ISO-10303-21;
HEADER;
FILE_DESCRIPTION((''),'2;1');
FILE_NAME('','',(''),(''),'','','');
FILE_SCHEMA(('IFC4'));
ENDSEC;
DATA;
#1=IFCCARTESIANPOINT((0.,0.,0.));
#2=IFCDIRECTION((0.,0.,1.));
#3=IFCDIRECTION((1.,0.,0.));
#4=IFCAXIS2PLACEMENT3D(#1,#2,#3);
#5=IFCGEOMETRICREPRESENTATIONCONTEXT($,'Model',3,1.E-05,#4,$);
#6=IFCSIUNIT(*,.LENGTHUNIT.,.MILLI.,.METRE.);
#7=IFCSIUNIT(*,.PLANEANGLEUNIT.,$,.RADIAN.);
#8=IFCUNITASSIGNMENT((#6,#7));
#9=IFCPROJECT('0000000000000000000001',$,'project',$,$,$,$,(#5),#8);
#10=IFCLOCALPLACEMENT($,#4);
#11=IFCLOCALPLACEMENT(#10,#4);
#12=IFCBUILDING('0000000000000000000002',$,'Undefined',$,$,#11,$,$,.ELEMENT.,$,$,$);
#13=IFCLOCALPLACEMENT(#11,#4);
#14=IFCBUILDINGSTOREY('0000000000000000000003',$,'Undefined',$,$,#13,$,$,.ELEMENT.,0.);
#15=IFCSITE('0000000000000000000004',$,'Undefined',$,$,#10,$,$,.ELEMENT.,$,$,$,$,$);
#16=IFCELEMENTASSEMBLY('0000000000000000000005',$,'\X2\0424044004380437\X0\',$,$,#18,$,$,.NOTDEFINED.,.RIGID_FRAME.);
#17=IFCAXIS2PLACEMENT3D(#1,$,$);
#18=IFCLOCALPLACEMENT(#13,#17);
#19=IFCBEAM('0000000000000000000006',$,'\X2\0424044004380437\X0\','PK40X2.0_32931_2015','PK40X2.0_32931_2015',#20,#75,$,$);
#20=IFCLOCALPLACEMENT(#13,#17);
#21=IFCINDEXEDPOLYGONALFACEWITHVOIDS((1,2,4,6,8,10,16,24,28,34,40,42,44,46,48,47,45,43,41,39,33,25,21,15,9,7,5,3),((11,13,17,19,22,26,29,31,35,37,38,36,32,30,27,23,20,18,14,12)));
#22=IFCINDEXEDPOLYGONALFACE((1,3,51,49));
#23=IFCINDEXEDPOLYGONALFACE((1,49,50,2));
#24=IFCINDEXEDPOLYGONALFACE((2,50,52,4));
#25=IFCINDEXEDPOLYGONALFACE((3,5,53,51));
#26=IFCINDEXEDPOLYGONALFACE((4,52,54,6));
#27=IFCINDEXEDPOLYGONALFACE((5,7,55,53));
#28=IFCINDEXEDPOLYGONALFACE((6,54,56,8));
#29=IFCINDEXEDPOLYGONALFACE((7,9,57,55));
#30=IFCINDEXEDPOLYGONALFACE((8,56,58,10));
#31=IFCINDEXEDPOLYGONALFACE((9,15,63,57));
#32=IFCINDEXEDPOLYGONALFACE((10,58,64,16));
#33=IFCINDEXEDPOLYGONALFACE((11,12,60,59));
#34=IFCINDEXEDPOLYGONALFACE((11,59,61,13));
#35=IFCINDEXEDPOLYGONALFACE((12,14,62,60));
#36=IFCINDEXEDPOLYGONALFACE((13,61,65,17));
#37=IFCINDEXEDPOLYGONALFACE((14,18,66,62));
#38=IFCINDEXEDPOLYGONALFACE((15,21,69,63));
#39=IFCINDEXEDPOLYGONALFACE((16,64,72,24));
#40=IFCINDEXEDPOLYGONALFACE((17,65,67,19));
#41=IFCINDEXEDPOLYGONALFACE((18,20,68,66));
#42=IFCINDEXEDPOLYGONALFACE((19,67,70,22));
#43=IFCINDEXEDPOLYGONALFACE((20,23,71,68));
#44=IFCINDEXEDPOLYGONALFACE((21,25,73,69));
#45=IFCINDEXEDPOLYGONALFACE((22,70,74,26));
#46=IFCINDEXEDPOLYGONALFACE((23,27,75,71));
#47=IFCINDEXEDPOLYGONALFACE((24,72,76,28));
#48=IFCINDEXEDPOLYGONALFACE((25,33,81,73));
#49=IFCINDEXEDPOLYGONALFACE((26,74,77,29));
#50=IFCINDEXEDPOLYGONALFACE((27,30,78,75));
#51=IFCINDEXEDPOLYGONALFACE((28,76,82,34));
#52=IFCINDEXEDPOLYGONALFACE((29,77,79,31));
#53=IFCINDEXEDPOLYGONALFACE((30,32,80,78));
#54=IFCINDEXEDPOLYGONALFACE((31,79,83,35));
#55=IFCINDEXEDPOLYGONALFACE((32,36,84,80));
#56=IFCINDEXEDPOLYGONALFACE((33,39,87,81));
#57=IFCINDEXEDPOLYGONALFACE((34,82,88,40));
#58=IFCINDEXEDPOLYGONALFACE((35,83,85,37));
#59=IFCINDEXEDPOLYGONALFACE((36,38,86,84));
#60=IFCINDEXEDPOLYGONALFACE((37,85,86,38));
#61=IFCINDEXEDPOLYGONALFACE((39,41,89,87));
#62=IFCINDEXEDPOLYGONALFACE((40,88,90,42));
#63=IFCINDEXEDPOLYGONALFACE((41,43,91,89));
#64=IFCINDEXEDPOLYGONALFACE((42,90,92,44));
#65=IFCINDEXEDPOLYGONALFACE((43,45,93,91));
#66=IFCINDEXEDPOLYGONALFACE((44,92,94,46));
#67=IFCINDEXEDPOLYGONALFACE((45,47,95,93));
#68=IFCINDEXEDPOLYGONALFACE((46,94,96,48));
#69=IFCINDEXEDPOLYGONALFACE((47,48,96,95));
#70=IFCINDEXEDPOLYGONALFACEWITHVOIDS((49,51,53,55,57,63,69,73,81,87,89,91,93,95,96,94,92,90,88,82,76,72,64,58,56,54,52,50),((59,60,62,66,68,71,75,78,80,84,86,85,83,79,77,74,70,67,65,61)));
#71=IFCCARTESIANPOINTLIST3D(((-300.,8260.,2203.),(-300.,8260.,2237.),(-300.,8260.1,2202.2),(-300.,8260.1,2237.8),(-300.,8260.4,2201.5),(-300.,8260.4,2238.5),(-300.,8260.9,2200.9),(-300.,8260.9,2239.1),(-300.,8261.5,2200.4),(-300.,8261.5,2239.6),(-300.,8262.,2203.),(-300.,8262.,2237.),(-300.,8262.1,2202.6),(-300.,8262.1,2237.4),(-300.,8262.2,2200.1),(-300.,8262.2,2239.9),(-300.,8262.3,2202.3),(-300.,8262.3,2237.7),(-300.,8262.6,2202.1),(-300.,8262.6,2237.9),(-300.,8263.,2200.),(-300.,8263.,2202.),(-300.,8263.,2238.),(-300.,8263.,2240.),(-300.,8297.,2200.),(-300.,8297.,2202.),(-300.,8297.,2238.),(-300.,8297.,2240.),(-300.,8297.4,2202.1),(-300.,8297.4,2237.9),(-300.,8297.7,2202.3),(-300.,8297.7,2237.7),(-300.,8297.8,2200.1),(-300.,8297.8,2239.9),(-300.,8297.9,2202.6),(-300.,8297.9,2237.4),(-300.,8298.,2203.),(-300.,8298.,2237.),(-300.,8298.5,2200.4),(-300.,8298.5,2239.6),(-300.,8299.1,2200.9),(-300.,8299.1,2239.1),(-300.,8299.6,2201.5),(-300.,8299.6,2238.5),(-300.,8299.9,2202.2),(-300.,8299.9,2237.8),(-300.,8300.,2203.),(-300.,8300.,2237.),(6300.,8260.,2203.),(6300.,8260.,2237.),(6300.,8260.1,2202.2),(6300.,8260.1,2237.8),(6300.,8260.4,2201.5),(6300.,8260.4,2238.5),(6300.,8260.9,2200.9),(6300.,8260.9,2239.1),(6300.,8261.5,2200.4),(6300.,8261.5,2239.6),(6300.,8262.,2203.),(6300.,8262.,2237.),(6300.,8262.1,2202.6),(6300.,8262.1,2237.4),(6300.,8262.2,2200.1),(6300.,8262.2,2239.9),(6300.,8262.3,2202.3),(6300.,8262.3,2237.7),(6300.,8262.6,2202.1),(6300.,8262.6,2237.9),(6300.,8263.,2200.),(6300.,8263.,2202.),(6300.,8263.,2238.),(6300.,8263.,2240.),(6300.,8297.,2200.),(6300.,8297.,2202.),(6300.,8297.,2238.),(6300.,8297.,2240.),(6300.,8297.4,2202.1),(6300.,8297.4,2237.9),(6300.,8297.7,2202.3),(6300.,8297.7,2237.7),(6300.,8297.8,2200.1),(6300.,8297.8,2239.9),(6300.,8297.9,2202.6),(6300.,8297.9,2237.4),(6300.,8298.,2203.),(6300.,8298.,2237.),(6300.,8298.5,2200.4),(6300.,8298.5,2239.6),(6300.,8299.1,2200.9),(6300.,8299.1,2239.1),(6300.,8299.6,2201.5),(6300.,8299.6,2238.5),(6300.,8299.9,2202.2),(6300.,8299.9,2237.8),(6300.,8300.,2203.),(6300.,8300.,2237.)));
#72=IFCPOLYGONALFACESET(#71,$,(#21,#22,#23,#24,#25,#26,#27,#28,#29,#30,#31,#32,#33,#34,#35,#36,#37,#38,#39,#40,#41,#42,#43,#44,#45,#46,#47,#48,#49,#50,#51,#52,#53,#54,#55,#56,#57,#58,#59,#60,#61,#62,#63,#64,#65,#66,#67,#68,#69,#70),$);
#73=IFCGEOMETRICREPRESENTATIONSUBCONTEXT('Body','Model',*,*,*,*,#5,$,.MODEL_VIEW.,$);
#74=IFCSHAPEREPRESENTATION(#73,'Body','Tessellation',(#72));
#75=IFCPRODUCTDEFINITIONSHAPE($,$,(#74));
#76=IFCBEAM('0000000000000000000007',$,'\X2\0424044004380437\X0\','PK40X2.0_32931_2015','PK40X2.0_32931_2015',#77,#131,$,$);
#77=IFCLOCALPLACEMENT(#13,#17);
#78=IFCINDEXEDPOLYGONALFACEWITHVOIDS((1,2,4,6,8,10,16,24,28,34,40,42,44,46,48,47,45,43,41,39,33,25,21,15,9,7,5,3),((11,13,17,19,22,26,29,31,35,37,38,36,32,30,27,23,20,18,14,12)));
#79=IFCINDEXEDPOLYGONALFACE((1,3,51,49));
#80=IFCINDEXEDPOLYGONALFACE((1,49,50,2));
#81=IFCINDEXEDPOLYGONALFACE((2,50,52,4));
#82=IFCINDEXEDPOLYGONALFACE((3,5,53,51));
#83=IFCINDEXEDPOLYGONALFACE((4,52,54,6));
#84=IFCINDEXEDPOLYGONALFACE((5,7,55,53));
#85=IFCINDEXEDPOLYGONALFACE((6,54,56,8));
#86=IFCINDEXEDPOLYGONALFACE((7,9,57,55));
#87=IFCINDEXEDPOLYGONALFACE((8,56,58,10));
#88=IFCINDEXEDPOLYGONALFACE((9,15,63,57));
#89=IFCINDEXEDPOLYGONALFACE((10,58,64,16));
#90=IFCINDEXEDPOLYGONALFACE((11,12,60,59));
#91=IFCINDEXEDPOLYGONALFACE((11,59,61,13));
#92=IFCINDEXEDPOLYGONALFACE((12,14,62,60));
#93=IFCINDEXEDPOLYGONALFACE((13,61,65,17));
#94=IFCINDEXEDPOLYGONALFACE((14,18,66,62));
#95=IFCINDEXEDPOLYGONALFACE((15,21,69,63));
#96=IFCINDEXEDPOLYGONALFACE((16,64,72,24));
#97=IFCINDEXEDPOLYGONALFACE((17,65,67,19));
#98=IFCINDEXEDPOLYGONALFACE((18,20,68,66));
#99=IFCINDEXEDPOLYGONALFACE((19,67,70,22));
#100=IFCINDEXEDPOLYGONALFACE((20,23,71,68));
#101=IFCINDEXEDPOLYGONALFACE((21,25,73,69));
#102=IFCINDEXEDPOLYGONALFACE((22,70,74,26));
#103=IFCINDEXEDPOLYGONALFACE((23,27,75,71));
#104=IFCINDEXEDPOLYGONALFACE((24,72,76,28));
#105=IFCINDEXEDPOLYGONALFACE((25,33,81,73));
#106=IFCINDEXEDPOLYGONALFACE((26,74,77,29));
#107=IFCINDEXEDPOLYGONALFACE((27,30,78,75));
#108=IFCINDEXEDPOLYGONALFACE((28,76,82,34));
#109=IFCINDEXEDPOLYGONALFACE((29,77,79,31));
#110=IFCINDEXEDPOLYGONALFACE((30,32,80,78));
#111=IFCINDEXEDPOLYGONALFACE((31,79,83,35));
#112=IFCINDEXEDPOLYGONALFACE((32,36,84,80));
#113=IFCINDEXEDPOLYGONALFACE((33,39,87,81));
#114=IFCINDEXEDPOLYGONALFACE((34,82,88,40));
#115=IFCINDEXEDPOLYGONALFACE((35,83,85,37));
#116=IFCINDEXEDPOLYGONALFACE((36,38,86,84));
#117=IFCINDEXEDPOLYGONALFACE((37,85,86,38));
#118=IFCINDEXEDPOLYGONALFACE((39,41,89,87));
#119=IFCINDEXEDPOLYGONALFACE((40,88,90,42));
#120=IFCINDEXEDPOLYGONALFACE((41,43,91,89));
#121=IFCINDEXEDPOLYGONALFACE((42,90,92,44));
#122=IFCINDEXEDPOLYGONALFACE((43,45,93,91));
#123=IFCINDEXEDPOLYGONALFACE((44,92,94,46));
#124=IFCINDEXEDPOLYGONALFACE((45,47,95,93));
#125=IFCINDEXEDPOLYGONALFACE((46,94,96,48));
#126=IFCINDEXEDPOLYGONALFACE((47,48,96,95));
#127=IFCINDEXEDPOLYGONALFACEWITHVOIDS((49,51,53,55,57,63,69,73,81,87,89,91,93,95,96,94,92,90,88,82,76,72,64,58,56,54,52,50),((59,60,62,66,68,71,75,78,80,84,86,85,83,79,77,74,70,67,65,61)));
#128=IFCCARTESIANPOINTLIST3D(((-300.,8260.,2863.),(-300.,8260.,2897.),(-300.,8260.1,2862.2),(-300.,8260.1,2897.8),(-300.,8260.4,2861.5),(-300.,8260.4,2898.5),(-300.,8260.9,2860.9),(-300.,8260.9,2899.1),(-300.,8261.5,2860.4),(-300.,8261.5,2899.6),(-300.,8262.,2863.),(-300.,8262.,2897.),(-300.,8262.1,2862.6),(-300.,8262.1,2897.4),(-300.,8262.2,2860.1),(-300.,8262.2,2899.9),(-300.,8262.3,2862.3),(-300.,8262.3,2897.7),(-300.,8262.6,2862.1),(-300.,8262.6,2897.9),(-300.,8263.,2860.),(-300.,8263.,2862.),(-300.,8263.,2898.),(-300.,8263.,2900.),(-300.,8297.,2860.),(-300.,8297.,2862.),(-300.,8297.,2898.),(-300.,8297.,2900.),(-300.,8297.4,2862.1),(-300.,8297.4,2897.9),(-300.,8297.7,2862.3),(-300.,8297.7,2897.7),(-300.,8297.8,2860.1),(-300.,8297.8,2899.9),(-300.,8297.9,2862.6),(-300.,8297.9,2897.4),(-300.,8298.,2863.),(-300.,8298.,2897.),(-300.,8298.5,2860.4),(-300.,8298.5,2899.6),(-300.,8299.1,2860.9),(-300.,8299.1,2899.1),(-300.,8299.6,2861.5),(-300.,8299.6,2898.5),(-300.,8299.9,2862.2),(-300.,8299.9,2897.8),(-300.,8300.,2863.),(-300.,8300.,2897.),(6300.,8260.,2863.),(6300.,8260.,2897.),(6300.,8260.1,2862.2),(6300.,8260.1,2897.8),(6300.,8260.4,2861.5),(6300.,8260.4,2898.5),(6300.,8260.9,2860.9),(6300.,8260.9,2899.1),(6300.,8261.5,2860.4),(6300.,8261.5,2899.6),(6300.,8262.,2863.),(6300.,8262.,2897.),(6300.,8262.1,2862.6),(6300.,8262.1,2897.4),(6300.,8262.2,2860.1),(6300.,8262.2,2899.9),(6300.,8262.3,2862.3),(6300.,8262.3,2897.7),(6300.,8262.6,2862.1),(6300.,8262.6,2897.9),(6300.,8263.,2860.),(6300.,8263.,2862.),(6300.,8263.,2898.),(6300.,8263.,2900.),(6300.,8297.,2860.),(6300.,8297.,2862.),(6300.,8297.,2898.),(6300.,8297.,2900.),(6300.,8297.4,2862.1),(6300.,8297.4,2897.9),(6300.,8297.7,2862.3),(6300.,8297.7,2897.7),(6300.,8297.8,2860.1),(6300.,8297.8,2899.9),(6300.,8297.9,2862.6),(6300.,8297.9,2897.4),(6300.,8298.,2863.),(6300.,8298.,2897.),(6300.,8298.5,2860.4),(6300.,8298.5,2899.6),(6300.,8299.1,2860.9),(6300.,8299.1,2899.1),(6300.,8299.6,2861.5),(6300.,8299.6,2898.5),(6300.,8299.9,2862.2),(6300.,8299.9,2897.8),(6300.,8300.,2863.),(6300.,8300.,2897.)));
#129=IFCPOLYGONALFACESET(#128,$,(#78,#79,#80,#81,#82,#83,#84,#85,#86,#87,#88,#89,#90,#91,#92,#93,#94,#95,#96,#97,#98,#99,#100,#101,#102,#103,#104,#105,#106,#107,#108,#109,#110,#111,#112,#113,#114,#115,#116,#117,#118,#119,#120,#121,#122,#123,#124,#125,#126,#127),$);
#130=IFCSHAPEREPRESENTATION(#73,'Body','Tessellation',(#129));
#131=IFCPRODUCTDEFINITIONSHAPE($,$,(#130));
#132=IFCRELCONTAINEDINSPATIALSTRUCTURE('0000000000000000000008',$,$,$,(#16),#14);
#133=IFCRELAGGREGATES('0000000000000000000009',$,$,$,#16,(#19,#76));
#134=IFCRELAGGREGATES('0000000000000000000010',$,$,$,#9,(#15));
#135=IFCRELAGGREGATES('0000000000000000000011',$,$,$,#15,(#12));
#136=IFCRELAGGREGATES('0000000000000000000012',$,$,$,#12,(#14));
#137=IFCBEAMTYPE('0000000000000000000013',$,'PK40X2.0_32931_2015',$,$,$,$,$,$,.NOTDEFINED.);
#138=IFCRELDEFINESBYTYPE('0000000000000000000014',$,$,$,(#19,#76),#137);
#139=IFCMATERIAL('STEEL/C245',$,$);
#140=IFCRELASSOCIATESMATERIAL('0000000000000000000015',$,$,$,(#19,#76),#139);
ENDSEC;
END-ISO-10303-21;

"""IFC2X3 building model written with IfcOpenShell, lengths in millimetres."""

from ifc_helpers import new_model, si_unit, frame, origin_with_axes, origin_2d_with_axis, place, context, subcontext, project, spatial, hollow_rectangle, extrude, material, type_object, element, aggregate, save


model = new_model("IFC2X3")

# Units and contexts
model_context = context("Model", 3, precision=1e-05, world=origin_with_axes())
body_context = subcontext(model_context, "Body", "Model", "MODEL_VIEW")
ifc_project = project(units=[si_unit("LENGTHUNIT", "METRE", prefix="MILLI"), si_unit("PLANEANGLEUNIT", "RADIAN")], contexts=[model_context])

# Site, building, storey
site_placement = place(None, origin_with_axes())
site = spatial("IfcSite", under=ifc_project, at=site_placement, Name="Undefined", CompositionType="ELEMENT")
building_placement = place(site_placement, origin_with_axes())
building = spatial("IfcBuilding", under=site, at=building_placement, Name="Undefined", CompositionType="ELEMENT")
storey_placement = place(building_placement, origin_with_axes())
storey = spatial("IfcBuildingStorey", under=building, at=storey_placement, Name="Undefined", CompositionType="ELEMENT", Elevation=0.0)

# Shared definitions
ifc_material_1 = material(Name="STEEL/C245")

# Shared definitions
beam_type_1 = type_object("IfcBeamType", Name="PK40X2.0_32931_2015", PredefinedType="NOTDEFINED")

# Element assembly, beams
assembly_1_placement = place(storey_placement, origin_with_axes())
assembly_1 = element("IfcElementAssembly", 1, at=assembly_1_placement, inside=storey, Name="Фриз", AssemblyPlace="NOTDEFINED", PredefinedType="RIGID_FRAME")
beam_1_placement = place(assembly_1_placement, frame((-300.0, 8280.0, 2220.0), z_axis=(0.0, 0.0, 1.0), x_axis=(1.0, 0.0, 0.0)))
beam_1 = element("IfcBeam", 2, at=beam_1_placement, type_object=beam_type_1, material=ifc_material_1, Name="Фриз", Description="PK40X2.0_32931_2015", ObjectType="PK40X2.0_32931_2015", context=body_context, shape_type="SweptSolid", body=[
    extrude(hollow_rectangle(XDim=40.0, YDim=40.0, WallThickness=2.0, InnerFilletRadius=1.0, OuterFilletRadius=3.0, at=origin_2d_with_axis()), frame((6600.0, 0.0, 0.0), z_axis=(-1.0, 0.0, 0.0), x_axis=(0.0, -1.0, 0.0)), (0.0, 0.0, 1.0), 6600.0),
])
beam_2_placement = place(assembly_1_placement, frame((-300.0, 8280.0, 2880.0), z_axis=(0.0, 0.0, 1.0), x_axis=(1.0, 0.0, 0.0)))
beam_2 = element("IfcBeam", 3, at=beam_2_placement, type_object=beam_type_1, material=ifc_material_1, Name="Фриз", Description="PK40X2.0_32931_2015", ObjectType="PK40X2.0_32931_2015", context=body_context, shape_type="SweptSolid", body=[
    extrude(hollow_rectangle(XDim=40.0, YDim=40.0, WallThickness=2.0, InnerFilletRadius=1.0, OuterFilletRadius=3.0, at=origin_2d_with_axis()), frame((6600.0, 0.0, 0.0), z_axis=(-1.0, 0.0, 0.0), x_axis=(0.0, -1.0, 0.0)), (0.0, 0.0, 1.0), 6600.0),
])
aggregate(assembly_1, [beam_1, beam_2])

save(model, "model.ifc")
